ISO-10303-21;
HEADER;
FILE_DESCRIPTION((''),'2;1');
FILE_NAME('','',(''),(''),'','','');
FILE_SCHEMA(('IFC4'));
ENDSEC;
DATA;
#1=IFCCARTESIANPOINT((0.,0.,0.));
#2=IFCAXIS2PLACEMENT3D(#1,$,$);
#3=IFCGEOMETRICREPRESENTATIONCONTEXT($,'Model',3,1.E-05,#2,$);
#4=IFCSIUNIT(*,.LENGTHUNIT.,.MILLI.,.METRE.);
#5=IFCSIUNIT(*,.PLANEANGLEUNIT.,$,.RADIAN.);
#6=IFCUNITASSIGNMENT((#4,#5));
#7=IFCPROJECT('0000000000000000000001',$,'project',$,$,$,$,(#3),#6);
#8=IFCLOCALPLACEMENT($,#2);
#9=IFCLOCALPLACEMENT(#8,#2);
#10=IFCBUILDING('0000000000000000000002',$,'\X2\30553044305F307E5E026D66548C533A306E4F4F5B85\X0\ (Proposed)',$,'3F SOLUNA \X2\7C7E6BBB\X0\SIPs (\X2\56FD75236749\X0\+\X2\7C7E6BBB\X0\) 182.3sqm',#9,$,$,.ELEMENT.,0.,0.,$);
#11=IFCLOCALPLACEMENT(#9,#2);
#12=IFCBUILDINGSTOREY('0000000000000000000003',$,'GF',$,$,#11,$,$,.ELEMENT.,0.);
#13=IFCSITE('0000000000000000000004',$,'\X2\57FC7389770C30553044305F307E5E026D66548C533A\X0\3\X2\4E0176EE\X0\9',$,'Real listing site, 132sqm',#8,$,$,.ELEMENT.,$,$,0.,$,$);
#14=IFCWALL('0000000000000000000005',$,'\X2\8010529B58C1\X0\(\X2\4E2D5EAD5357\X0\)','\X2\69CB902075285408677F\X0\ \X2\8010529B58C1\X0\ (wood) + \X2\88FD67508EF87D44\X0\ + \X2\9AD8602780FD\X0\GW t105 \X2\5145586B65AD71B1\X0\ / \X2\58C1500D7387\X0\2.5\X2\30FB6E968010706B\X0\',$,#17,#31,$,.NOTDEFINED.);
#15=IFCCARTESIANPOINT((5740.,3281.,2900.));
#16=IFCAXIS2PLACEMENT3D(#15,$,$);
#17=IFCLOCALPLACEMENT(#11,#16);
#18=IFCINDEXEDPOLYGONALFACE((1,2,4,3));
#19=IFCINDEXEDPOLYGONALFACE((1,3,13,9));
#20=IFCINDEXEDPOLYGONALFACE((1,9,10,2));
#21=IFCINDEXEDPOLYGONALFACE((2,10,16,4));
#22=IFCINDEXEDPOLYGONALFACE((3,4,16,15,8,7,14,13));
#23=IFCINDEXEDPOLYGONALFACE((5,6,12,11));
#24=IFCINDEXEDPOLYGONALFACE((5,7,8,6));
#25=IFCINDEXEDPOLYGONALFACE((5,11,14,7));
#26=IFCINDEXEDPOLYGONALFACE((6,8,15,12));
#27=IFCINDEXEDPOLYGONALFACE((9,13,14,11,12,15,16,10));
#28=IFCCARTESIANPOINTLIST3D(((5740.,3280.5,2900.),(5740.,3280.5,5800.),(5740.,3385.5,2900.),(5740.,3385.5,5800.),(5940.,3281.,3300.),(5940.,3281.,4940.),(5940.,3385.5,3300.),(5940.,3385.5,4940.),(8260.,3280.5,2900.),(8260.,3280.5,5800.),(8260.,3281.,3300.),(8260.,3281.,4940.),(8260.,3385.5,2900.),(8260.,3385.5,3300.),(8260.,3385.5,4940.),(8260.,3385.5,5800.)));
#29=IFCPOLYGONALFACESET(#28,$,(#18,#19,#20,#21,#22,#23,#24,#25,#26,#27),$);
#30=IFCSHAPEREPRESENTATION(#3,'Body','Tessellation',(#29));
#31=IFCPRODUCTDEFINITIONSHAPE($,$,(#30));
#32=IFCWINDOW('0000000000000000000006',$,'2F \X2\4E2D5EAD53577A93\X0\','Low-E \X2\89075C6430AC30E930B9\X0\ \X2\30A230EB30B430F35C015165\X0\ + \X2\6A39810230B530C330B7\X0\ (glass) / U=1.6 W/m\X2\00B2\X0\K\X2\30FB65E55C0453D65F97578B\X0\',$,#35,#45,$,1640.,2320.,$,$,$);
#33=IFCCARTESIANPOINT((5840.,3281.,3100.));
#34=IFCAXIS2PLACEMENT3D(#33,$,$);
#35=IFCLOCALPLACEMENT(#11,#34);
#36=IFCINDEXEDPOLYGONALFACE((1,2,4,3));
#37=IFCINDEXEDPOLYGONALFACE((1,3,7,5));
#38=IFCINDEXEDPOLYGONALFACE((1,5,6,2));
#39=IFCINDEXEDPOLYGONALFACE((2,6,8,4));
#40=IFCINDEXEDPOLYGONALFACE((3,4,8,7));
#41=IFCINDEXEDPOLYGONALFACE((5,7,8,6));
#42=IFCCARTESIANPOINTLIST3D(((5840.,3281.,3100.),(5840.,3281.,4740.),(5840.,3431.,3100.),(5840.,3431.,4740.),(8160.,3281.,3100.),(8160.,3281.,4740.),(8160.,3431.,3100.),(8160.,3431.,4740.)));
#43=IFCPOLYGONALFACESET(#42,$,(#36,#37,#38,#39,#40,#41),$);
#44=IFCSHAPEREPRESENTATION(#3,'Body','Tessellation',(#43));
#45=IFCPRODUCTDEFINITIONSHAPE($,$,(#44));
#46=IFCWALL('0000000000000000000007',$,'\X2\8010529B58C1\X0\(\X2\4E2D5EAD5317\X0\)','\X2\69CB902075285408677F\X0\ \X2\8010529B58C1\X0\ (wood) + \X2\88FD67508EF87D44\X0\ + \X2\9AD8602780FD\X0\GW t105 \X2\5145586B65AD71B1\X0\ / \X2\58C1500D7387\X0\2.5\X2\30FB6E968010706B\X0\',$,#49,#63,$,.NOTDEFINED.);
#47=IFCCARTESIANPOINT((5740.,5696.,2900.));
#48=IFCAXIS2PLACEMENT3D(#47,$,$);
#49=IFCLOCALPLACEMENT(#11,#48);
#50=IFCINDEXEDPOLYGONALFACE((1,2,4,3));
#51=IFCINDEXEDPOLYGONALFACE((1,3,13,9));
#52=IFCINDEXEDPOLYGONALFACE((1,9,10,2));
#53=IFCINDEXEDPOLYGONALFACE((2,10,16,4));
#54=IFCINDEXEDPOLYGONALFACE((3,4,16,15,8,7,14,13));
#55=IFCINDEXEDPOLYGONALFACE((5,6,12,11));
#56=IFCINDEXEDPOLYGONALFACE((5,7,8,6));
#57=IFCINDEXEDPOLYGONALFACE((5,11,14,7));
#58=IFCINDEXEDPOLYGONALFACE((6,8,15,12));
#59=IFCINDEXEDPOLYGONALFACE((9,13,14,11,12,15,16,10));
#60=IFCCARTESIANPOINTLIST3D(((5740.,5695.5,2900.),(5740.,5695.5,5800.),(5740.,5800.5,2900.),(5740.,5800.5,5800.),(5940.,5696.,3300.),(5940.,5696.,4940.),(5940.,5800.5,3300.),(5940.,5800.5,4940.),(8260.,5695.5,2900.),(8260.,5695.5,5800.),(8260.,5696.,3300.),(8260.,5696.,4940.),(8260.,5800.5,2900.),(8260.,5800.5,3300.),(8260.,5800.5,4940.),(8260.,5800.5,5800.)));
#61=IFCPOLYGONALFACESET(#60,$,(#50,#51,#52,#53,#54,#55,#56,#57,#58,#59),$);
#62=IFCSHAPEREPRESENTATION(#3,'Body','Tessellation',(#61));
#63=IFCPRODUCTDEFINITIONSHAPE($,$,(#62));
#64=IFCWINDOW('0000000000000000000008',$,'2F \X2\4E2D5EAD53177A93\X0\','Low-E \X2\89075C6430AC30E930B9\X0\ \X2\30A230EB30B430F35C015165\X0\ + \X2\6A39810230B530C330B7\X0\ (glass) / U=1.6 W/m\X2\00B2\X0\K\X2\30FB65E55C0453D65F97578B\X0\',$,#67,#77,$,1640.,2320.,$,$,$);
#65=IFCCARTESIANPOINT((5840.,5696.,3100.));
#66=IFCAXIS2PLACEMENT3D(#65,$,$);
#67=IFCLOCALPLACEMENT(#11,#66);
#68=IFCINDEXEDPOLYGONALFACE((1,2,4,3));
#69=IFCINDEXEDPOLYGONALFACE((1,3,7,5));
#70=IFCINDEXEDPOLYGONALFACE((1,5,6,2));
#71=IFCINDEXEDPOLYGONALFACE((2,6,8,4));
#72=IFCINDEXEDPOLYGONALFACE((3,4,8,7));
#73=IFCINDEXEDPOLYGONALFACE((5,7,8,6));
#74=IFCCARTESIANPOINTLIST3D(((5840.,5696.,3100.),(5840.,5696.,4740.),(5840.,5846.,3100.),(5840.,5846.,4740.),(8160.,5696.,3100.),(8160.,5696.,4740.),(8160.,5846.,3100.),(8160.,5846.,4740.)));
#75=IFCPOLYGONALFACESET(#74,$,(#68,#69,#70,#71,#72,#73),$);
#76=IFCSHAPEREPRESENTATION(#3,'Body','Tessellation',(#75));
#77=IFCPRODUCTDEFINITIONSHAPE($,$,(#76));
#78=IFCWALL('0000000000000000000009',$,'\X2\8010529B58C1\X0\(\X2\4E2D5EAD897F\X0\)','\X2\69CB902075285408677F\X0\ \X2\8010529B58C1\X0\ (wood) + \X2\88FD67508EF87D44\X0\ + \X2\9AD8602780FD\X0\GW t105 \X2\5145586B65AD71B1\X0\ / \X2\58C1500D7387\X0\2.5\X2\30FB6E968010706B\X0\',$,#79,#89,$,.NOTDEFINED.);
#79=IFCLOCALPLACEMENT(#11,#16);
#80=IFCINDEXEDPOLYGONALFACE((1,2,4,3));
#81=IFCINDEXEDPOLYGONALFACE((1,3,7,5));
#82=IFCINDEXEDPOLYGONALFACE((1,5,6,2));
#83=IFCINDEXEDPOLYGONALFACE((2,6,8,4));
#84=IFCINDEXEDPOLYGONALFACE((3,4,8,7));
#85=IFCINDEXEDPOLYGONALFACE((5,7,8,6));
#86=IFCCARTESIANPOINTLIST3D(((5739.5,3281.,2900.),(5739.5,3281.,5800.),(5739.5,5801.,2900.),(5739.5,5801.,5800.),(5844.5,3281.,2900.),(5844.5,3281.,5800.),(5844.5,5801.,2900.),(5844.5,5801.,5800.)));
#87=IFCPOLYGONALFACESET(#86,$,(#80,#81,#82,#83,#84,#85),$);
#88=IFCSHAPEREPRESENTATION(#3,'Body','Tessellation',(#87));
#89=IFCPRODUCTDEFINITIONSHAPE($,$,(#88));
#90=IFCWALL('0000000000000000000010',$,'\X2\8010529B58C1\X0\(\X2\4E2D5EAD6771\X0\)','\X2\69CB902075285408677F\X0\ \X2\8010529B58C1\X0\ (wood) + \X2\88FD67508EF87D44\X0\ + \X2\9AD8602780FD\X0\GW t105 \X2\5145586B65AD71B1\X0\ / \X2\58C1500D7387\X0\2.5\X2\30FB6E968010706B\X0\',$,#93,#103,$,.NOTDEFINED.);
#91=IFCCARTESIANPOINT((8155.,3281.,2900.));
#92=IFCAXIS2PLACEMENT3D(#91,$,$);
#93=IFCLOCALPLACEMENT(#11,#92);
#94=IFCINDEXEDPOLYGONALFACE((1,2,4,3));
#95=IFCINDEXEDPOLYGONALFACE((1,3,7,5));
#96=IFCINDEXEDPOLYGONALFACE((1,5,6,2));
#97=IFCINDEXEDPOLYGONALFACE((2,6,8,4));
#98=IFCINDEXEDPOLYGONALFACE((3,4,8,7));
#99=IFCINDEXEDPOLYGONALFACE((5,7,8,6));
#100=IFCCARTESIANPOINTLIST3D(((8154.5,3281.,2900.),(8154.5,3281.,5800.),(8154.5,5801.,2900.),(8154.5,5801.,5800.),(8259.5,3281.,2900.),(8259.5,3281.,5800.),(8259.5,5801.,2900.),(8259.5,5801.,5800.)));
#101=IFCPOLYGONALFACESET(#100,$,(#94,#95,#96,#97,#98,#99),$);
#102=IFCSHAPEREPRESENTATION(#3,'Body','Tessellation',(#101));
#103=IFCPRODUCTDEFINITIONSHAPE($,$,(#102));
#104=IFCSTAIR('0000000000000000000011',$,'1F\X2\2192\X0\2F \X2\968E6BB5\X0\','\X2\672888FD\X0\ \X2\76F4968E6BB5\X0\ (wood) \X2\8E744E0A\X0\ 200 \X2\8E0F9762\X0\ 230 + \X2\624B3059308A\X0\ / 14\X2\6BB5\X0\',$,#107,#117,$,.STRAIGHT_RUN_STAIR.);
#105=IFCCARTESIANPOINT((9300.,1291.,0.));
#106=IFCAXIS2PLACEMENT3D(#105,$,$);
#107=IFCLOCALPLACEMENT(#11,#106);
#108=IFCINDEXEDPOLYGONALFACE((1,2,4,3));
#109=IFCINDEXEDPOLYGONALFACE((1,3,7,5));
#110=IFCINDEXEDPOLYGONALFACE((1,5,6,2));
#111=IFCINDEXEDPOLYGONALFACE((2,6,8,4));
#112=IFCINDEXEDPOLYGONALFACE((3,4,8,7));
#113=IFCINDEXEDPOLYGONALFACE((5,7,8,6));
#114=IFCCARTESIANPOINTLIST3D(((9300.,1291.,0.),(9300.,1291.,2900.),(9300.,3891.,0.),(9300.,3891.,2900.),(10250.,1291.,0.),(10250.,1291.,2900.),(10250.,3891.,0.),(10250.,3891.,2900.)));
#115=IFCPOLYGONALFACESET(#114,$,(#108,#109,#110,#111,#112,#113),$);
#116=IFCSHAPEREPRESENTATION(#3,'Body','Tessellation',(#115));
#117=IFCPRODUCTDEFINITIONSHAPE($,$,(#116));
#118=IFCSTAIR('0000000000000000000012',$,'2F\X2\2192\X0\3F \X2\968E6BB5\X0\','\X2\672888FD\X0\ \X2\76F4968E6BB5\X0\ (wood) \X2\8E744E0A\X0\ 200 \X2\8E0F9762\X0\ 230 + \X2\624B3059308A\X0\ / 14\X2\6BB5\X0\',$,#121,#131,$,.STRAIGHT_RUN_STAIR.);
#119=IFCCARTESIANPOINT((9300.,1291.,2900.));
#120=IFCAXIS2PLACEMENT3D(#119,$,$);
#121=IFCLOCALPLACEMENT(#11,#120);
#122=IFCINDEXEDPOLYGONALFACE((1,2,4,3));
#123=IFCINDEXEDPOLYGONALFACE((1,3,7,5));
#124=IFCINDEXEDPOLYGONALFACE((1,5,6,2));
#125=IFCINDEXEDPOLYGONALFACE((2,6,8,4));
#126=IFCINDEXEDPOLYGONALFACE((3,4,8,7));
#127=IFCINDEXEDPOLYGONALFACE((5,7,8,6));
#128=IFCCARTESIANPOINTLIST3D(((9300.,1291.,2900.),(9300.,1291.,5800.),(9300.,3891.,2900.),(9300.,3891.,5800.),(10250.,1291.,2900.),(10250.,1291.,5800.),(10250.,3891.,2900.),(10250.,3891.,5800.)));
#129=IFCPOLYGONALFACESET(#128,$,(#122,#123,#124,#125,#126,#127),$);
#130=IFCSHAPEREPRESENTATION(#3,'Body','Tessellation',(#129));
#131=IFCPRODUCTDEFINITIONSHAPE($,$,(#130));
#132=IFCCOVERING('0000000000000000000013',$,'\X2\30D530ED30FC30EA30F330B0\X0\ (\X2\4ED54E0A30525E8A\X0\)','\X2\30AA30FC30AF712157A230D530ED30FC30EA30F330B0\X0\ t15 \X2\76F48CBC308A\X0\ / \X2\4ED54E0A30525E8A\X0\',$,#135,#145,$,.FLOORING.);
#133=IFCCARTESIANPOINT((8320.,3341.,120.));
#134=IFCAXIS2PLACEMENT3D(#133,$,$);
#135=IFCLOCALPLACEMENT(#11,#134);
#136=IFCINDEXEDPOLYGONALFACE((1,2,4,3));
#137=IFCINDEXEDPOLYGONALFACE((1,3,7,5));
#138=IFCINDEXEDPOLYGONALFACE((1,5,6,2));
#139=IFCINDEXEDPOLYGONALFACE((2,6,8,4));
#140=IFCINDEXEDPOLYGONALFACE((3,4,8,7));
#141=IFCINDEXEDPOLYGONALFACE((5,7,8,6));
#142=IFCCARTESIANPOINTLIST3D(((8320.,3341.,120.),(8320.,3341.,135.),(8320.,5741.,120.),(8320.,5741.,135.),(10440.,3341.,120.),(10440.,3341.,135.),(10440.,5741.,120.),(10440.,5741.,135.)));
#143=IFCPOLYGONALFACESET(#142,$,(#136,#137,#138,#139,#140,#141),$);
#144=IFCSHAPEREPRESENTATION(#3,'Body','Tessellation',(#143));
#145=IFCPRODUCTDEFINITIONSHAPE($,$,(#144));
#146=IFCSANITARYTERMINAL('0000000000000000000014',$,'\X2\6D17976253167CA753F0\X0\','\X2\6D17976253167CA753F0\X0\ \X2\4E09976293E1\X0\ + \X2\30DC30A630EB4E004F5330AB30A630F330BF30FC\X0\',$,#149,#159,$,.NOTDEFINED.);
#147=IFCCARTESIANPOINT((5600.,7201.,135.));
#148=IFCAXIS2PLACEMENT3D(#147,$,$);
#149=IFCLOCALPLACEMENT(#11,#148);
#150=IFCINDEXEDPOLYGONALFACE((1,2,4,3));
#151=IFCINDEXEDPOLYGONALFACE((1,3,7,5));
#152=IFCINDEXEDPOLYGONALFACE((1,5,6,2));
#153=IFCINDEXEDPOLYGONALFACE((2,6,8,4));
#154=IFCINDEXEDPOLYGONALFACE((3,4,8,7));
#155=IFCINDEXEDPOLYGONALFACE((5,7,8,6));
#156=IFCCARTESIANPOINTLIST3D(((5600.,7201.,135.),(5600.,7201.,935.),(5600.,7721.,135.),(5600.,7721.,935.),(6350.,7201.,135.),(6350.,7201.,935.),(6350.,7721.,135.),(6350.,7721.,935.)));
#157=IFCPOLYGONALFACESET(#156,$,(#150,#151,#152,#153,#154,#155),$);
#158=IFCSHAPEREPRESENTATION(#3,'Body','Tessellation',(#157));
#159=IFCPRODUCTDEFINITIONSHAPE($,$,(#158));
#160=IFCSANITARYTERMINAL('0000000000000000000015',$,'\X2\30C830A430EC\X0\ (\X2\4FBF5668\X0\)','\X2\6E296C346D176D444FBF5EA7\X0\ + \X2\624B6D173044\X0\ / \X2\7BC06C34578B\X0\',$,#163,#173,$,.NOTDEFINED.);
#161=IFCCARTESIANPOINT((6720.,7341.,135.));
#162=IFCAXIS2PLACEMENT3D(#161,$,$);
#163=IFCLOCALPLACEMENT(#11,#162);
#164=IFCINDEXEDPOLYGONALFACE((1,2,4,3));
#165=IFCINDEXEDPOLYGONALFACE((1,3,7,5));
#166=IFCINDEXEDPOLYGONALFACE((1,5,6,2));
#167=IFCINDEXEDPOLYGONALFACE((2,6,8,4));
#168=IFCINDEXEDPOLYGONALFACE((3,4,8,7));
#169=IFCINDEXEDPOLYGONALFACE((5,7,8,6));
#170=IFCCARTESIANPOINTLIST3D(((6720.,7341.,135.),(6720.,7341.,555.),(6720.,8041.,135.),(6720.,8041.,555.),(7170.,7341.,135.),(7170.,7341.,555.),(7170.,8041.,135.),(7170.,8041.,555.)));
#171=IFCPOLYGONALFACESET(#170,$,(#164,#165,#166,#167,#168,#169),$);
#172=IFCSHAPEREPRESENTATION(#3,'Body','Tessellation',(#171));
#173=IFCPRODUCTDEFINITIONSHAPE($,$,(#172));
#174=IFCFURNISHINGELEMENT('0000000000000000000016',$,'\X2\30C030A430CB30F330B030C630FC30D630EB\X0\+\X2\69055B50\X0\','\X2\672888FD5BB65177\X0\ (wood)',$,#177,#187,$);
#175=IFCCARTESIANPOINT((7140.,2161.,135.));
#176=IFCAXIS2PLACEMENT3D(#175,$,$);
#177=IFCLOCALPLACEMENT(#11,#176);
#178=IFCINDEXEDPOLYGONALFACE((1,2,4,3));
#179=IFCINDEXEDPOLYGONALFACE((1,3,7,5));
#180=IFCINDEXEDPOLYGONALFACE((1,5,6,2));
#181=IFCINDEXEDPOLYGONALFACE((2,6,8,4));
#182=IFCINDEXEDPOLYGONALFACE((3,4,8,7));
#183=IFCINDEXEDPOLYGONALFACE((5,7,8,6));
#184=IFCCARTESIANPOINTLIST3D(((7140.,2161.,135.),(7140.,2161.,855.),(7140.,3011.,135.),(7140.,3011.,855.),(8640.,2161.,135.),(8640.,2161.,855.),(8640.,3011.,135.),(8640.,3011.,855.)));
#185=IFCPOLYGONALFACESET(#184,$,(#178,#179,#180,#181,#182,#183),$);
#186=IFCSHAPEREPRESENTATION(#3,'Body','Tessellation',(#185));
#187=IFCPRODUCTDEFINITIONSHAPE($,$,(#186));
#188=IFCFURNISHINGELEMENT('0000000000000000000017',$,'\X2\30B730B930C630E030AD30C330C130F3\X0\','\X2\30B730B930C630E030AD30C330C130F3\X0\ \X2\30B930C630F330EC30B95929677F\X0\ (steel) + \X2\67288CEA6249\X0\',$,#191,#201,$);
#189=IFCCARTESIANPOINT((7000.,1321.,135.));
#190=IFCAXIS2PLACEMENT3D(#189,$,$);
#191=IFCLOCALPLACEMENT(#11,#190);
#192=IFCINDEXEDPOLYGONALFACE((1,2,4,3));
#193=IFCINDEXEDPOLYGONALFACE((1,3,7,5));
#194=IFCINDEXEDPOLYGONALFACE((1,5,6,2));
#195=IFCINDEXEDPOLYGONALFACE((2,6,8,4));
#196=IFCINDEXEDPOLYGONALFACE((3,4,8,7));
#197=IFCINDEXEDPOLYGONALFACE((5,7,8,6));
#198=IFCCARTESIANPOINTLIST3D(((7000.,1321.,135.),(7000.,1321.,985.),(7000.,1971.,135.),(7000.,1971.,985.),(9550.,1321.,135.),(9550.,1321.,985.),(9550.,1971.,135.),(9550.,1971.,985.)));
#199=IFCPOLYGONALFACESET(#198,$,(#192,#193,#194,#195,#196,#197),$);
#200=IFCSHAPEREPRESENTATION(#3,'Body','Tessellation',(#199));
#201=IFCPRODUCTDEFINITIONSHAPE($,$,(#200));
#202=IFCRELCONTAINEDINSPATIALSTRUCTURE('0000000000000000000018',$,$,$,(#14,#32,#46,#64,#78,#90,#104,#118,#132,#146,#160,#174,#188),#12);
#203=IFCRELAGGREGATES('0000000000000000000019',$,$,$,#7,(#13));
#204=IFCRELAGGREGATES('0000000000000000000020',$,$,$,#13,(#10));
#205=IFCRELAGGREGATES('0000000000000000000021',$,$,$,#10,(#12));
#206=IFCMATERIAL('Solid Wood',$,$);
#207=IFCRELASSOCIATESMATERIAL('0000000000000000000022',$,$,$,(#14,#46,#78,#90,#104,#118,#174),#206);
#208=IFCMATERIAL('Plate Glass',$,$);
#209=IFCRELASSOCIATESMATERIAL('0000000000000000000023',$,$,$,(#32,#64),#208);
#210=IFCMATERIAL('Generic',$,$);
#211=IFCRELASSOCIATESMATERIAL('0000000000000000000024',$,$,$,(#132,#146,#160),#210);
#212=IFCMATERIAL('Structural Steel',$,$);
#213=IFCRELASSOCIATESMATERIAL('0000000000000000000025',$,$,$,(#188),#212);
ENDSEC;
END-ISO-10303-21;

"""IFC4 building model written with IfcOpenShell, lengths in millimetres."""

from ifc_helpers import new_model, si_unit, frame, frame_2d, origin, place, context, project, spatial, rectangle, extrude, material, element, fill, save


model = new_model("IFC4")

# Units and contexts
model_context = context("Model", 3, precision=1e-05, world=origin())
ifc_project = project(units=[si_unit("LENGTHUNIT", "METRE", prefix="MILLI"), si_unit("PLANEANGLEUNIT", "RADIAN")], contexts=[model_context])

# Site, building, storey
site_placement = place(None, origin())
site = spatial("IfcSite", under=ifc_project, at=site_placement, Name="埼玉県さいたま市浦和区3丁目9", ObjectType="Real listing site, 132sqm", CompositionType="ELEMENT", RefElevation=0.0)
building_placement = place(site_placement, origin())
building = spatial("IfcBuilding", under=site, at=building_placement, Name="さいたま市浦和区の住宅 (Proposed)", ObjectType="3F SOLUNA 籾殻SIPs (国産杉+籾殻) 182.3sqm", CompositionType="ELEMENT", ElevationOfRefHeight=0.0, ElevationOfTerrain=0.0)
storey_placement = place(building_placement, origin())
storey = spatial("IfcBuildingStorey", under=building, at=storey_placement, Name="GF", CompositionType="ELEMENT", Elevation=0.0)

# Shared definitions
ifc_material_1 = material(Name="Solid Wood")

# Shared definitions
ifc_material_2 = material(Name="Plate Glass")

# Walls, openings, windows
wall_1_placement = place(storey_placement, frame((5740.0, 3281.0, 2900.0)))
wall_1 = element("IfcWall", 1, at=wall_1_placement, inside=storey, material=ifc_material_1, Name="耐力壁(中庭南)", Description="構造用合板 耐力壁 (wood) + 製材軸組 + 高性能GW t105 充填断熱 / 壁倍率2.5・準耐火", PredefinedType="NOTDEFINED", context=model_context, shape_type="SweptSolid", body=[
    extrude(rectangle(XDim=2520.0, YDim=105.0, at=frame_2d((1260.0, 52.0))), frame((5740.0, 3281.0, 2900.0)), (0.0, 0.0, 1.0), 2900.0),
])
opening_1_placement = place(storey_placement, frame((5840.0, 3281.0, 3100.0)))
opening_1 = element("IfcOpeningElement", 2, at=opening_1_placement, cuts=wall_1, PredefinedType="NOTDEFINED", context=model_context, shape_type="SweptSolid", body=[
    extrude(rectangle(XDim=2320.0, YDim=150.0, at=frame_2d((1160.0, 75.0))), frame((5840.0, 3281.0, 3100.0)), (0.0, 0.0, 1.0), 1640.0),
])
window_1_placement = place(storey_placement, frame((5840.0, 3281.0, 3100.0)))
window_1 = element("IfcWindow", 3, at=window_1_placement, inside=storey, material=ifc_material_2, Name="2F 中庭南窓", Description="Low-E 複層ガラス アルゴン封入 + 樹脂サッシ (glass) / U=1.6 W/m²K・日射取得型", OverallHeight=1640.0, OverallWidth=2320.0, context=model_context, shape_type="SweptSolid", body=[
    extrude(rectangle(XDim=2320.0, YDim=150.0, at=frame_2d((1160.0, 75.0))), frame((5840.0, 3281.0, 3100.0)), (0.0, 0.0, 1.0), 1640.0),
])
fill(opening_1, window_1)
wall_2_placement = place(storey_placement, frame((5740.0, 5696.0, 2900.0)))
wall_2 = element("IfcWall", 4, at=wall_2_placement, inside=storey, material=ifc_material_1, Name="耐力壁(中庭北)", Description="構造用合板 耐力壁 (wood) + 製材軸組 + 高性能GW t105 充填断熱 / 壁倍率2.5・準耐火", PredefinedType="NOTDEFINED", context=model_context, shape_type="SweptSolid", body=[
    extrude(rectangle(XDim=2520.0, YDim=105.0, at=frame_2d((1260.0, 52.0))), frame((5740.0, 5696.0, 2900.0)), (0.0, 0.0, 1.0), 2900.0),
])
opening_2_placement = place(storey_placement, frame((5840.0, 5696.0, 3100.0)))
opening_2 = element("IfcOpeningElement", 5, at=opening_2_placement, cuts=wall_2, PredefinedType="NOTDEFINED", context=model_context, shape_type="SweptSolid", body=[
    extrude(rectangle(XDim=2320.0, YDim=150.0, at=frame_2d((1160.0, 75.0))), frame((5840.0, 5696.0, 3100.0)), (0.0, 0.0, 1.0), 1640.0),
])
window_2_placement = place(storey_placement, frame((5840.0, 5696.0, 3100.0)))
window_2 = element("IfcWindow", 6, at=window_2_placement, inside=storey, material=ifc_material_2, Name="2F 中庭北窓", Description="Low-E 複層ガラス アルゴン封入 + 樹脂サッシ (glass) / U=1.6 W/m²K・日射取得型", OverallHeight=1640.0, OverallWidth=2320.0, context=model_context, shape_type="SweptSolid", body=[
    extrude(rectangle(XDim=2320.0, YDim=150.0, at=frame_2d((1160.0, 75.0))), frame((5840.0, 5696.0, 3100.0)), (0.0, 0.0, 1.0), 1640.0),
])
fill(opening_2, window_2)

# Walls
wall_3_placement = place(storey_placement, frame((5740.0, 3281.0, 2900.0)))
element("IfcWall", 7, at=wall_3_placement, inside=storey, material=ifc_material_1, Name="耐力壁(中庭西)", Description="構造用合板 耐力壁 (wood) + 製材軸組 + 高性能GW t105 充填断熱 / 壁倍率2.5・準耐火", PredefinedType="NOTDEFINED", context=model_context, shape_type="SweptSolid", body=[
    extrude(rectangle(XDim=105.0, YDim=2520.0, at=frame_2d((52.0, 1260.0))), frame((5740.0, 3281.0, 2900.0)), (0.0, 0.0, 1.0), 2900.0),
])
wall_4_placement = place(storey_placement, frame((8155.0, 3281.0, 2900.0)))
element("IfcWall", 8, at=wall_4_placement, inside=storey, material=ifc_material_1, Name="耐力壁(中庭東)", Description="構造用合板 耐力壁 (wood) + 製材軸組 + 高性能GW t105 充填断熱 / 壁倍率2.5・準耐火", PredefinedType="NOTDEFINED", context=model_context, shape_type="SweptSolid", body=[
    extrude(rectangle(XDim=105.0, YDim=2520.0, at=frame_2d((52.0, 1260.0))), frame((8155.0, 3281.0, 2900.0)), (0.0, 0.0, 1.0), 2900.0),
])

# Stairs
stair_1_placement = place(storey_placement, frame((9300.0, 1291.0, 0.0)))
element("IfcStair", 9, at=stair_1_placement, inside=storey, material=ifc_material_1, Name="1F→2F 階段", Description="木製 直階段 (wood) 蹴上 200 踏面 230 + 手すり / 14段", PredefinedType="STRAIGHT_RUN_STAIR", context=model_context, shape_type="SweptSolid", body=[
    extrude(rectangle(XDim=950.0, YDim=2600.0, at=frame_2d((475.0, 1300.0))), frame((9300.0, 1291.0, 0.0)), (0.0, 0.0, 1.0), 2900.0),
])
stair_2_placement = place(storey_placement, frame((9300.0, 1291.0, 2900.0)))
element("IfcStair", 10, at=stair_2_placement, inside=storey, material=ifc_material_1, Name="2F→3F 階段", Description="木製 直階段 (wood) 蹴上 200 踏面 230 + 手すり / 14段", PredefinedType="STRAIGHT_RUN_STAIR", context=model_context, shape_type="SweptSolid", body=[
    extrude(rectangle(XDim=950.0, YDim=2600.0, at=frame_2d((475.0, 1300.0))), frame((9300.0, 1291.0, 2900.0)), (0.0, 0.0, 1.0), 2900.0),
])

# Covering
ifc_material_3 = material(Name="Generic")
covering_placement = place(storey_placement, frame((8320.0, 3341.0, 120.0)))
element("IfcCovering", 11, at=covering_placement, inside=storey, material=ifc_material_3, Name="フローリング (仕上げ床)", Description="オーク無垢フローリング t15 直貼り / 仕上げ床", PredefinedType="FLOORING", context=model_context, shape_type="SweptSolid", body=[
    extrude(rectangle(XDim=2120.0, YDim=2400.0, at=frame_2d((1060.0, 1200.0))), frame((8320.0, 3341.0, 120.0)), (0.0, 0.0, 1.0), 15.0),
])

# Sanitary terminals
sanitary_terminal_1_placement = place(storey_placement, frame((5600.0, 7201.0, 135.0)))
element("IfcSanitaryTerminal", 12, at=sanitary_terminal_1_placement, inside=storey, material=ifc_material_3, Name="洗面化粧台", Description="洗面化粧台 三面鏡 + ボウル一体カウンター", PredefinedType="NOTDEFINED", context=model_context, shape_type="SweptSolid", body=[
    extrude(rectangle(XDim=750.0, YDim=520.0, at=frame_2d((375.0, 260.0))), frame((5600.0, 7201.0, 135.0)), (0.0, 0.0, 1.0), 800.0),
])
sanitary_terminal_2_placement = place(storey_placement, frame((6720.0, 7341.0, 135.0)))
element("IfcSanitaryTerminal", 13, at=sanitary_terminal_2_placement, inside=storey, material=ifc_material_3, Name="トイレ (便器)", Description="温水洗浄便座 + 手洗い / 節水型", PredefinedType="NOTDEFINED", context=model_context, shape_type="SweptSolid", body=[
    extrude(rectangle(XDim=450.0, YDim=700.0, at=frame_2d((225.0, 350.0))), frame((6720.0, 7341.0, 135.0)), (0.0, 0.0, 1.0), 420.0),
])

# Furnishing elements
furnishing_1_placement = place(storey_placement, frame((7140.0, 2161.0, 135.0)))
element("IfcFurnishingElement", 14, at=furnishing_1_placement, inside=storey, material=ifc_material_1, Name="ダイニングテーブル+椅子", Description="木製家具 (wood)", context=model_context, shape_type="SweptSolid", body=[
    extrude(rectangle(XDim=1500.0, YDim=850.0, at=frame_2d((750.0, 425.0))), frame((7140.0, 2161.0, 135.0)), (0.0, 0.0, 1.0), 720.0),
])
ifc_material_4 = material(Name="Structural Steel")
furnishing_2_placement = place(storey_placement, frame((7000.0, 1321.0, 135.0)))
element("IfcFurnishingElement", 15, at=furnishing_2_placement, inside=storey, material=ifc_material_4, Name="システムキッチン", Description="システムキッチン ステンレス天板 (steel) + 木質扉", context=model_context, shape_type="SweptSolid", body=[
    extrude(rectangle(XDim=2550.0, YDim=650.0, at=frame_2d((1275.0, 325.0))), frame((7000.0, 1321.0, 135.0)), (0.0, 0.0, 1.0), 850.0),
])

save(model, "model.ifc")
